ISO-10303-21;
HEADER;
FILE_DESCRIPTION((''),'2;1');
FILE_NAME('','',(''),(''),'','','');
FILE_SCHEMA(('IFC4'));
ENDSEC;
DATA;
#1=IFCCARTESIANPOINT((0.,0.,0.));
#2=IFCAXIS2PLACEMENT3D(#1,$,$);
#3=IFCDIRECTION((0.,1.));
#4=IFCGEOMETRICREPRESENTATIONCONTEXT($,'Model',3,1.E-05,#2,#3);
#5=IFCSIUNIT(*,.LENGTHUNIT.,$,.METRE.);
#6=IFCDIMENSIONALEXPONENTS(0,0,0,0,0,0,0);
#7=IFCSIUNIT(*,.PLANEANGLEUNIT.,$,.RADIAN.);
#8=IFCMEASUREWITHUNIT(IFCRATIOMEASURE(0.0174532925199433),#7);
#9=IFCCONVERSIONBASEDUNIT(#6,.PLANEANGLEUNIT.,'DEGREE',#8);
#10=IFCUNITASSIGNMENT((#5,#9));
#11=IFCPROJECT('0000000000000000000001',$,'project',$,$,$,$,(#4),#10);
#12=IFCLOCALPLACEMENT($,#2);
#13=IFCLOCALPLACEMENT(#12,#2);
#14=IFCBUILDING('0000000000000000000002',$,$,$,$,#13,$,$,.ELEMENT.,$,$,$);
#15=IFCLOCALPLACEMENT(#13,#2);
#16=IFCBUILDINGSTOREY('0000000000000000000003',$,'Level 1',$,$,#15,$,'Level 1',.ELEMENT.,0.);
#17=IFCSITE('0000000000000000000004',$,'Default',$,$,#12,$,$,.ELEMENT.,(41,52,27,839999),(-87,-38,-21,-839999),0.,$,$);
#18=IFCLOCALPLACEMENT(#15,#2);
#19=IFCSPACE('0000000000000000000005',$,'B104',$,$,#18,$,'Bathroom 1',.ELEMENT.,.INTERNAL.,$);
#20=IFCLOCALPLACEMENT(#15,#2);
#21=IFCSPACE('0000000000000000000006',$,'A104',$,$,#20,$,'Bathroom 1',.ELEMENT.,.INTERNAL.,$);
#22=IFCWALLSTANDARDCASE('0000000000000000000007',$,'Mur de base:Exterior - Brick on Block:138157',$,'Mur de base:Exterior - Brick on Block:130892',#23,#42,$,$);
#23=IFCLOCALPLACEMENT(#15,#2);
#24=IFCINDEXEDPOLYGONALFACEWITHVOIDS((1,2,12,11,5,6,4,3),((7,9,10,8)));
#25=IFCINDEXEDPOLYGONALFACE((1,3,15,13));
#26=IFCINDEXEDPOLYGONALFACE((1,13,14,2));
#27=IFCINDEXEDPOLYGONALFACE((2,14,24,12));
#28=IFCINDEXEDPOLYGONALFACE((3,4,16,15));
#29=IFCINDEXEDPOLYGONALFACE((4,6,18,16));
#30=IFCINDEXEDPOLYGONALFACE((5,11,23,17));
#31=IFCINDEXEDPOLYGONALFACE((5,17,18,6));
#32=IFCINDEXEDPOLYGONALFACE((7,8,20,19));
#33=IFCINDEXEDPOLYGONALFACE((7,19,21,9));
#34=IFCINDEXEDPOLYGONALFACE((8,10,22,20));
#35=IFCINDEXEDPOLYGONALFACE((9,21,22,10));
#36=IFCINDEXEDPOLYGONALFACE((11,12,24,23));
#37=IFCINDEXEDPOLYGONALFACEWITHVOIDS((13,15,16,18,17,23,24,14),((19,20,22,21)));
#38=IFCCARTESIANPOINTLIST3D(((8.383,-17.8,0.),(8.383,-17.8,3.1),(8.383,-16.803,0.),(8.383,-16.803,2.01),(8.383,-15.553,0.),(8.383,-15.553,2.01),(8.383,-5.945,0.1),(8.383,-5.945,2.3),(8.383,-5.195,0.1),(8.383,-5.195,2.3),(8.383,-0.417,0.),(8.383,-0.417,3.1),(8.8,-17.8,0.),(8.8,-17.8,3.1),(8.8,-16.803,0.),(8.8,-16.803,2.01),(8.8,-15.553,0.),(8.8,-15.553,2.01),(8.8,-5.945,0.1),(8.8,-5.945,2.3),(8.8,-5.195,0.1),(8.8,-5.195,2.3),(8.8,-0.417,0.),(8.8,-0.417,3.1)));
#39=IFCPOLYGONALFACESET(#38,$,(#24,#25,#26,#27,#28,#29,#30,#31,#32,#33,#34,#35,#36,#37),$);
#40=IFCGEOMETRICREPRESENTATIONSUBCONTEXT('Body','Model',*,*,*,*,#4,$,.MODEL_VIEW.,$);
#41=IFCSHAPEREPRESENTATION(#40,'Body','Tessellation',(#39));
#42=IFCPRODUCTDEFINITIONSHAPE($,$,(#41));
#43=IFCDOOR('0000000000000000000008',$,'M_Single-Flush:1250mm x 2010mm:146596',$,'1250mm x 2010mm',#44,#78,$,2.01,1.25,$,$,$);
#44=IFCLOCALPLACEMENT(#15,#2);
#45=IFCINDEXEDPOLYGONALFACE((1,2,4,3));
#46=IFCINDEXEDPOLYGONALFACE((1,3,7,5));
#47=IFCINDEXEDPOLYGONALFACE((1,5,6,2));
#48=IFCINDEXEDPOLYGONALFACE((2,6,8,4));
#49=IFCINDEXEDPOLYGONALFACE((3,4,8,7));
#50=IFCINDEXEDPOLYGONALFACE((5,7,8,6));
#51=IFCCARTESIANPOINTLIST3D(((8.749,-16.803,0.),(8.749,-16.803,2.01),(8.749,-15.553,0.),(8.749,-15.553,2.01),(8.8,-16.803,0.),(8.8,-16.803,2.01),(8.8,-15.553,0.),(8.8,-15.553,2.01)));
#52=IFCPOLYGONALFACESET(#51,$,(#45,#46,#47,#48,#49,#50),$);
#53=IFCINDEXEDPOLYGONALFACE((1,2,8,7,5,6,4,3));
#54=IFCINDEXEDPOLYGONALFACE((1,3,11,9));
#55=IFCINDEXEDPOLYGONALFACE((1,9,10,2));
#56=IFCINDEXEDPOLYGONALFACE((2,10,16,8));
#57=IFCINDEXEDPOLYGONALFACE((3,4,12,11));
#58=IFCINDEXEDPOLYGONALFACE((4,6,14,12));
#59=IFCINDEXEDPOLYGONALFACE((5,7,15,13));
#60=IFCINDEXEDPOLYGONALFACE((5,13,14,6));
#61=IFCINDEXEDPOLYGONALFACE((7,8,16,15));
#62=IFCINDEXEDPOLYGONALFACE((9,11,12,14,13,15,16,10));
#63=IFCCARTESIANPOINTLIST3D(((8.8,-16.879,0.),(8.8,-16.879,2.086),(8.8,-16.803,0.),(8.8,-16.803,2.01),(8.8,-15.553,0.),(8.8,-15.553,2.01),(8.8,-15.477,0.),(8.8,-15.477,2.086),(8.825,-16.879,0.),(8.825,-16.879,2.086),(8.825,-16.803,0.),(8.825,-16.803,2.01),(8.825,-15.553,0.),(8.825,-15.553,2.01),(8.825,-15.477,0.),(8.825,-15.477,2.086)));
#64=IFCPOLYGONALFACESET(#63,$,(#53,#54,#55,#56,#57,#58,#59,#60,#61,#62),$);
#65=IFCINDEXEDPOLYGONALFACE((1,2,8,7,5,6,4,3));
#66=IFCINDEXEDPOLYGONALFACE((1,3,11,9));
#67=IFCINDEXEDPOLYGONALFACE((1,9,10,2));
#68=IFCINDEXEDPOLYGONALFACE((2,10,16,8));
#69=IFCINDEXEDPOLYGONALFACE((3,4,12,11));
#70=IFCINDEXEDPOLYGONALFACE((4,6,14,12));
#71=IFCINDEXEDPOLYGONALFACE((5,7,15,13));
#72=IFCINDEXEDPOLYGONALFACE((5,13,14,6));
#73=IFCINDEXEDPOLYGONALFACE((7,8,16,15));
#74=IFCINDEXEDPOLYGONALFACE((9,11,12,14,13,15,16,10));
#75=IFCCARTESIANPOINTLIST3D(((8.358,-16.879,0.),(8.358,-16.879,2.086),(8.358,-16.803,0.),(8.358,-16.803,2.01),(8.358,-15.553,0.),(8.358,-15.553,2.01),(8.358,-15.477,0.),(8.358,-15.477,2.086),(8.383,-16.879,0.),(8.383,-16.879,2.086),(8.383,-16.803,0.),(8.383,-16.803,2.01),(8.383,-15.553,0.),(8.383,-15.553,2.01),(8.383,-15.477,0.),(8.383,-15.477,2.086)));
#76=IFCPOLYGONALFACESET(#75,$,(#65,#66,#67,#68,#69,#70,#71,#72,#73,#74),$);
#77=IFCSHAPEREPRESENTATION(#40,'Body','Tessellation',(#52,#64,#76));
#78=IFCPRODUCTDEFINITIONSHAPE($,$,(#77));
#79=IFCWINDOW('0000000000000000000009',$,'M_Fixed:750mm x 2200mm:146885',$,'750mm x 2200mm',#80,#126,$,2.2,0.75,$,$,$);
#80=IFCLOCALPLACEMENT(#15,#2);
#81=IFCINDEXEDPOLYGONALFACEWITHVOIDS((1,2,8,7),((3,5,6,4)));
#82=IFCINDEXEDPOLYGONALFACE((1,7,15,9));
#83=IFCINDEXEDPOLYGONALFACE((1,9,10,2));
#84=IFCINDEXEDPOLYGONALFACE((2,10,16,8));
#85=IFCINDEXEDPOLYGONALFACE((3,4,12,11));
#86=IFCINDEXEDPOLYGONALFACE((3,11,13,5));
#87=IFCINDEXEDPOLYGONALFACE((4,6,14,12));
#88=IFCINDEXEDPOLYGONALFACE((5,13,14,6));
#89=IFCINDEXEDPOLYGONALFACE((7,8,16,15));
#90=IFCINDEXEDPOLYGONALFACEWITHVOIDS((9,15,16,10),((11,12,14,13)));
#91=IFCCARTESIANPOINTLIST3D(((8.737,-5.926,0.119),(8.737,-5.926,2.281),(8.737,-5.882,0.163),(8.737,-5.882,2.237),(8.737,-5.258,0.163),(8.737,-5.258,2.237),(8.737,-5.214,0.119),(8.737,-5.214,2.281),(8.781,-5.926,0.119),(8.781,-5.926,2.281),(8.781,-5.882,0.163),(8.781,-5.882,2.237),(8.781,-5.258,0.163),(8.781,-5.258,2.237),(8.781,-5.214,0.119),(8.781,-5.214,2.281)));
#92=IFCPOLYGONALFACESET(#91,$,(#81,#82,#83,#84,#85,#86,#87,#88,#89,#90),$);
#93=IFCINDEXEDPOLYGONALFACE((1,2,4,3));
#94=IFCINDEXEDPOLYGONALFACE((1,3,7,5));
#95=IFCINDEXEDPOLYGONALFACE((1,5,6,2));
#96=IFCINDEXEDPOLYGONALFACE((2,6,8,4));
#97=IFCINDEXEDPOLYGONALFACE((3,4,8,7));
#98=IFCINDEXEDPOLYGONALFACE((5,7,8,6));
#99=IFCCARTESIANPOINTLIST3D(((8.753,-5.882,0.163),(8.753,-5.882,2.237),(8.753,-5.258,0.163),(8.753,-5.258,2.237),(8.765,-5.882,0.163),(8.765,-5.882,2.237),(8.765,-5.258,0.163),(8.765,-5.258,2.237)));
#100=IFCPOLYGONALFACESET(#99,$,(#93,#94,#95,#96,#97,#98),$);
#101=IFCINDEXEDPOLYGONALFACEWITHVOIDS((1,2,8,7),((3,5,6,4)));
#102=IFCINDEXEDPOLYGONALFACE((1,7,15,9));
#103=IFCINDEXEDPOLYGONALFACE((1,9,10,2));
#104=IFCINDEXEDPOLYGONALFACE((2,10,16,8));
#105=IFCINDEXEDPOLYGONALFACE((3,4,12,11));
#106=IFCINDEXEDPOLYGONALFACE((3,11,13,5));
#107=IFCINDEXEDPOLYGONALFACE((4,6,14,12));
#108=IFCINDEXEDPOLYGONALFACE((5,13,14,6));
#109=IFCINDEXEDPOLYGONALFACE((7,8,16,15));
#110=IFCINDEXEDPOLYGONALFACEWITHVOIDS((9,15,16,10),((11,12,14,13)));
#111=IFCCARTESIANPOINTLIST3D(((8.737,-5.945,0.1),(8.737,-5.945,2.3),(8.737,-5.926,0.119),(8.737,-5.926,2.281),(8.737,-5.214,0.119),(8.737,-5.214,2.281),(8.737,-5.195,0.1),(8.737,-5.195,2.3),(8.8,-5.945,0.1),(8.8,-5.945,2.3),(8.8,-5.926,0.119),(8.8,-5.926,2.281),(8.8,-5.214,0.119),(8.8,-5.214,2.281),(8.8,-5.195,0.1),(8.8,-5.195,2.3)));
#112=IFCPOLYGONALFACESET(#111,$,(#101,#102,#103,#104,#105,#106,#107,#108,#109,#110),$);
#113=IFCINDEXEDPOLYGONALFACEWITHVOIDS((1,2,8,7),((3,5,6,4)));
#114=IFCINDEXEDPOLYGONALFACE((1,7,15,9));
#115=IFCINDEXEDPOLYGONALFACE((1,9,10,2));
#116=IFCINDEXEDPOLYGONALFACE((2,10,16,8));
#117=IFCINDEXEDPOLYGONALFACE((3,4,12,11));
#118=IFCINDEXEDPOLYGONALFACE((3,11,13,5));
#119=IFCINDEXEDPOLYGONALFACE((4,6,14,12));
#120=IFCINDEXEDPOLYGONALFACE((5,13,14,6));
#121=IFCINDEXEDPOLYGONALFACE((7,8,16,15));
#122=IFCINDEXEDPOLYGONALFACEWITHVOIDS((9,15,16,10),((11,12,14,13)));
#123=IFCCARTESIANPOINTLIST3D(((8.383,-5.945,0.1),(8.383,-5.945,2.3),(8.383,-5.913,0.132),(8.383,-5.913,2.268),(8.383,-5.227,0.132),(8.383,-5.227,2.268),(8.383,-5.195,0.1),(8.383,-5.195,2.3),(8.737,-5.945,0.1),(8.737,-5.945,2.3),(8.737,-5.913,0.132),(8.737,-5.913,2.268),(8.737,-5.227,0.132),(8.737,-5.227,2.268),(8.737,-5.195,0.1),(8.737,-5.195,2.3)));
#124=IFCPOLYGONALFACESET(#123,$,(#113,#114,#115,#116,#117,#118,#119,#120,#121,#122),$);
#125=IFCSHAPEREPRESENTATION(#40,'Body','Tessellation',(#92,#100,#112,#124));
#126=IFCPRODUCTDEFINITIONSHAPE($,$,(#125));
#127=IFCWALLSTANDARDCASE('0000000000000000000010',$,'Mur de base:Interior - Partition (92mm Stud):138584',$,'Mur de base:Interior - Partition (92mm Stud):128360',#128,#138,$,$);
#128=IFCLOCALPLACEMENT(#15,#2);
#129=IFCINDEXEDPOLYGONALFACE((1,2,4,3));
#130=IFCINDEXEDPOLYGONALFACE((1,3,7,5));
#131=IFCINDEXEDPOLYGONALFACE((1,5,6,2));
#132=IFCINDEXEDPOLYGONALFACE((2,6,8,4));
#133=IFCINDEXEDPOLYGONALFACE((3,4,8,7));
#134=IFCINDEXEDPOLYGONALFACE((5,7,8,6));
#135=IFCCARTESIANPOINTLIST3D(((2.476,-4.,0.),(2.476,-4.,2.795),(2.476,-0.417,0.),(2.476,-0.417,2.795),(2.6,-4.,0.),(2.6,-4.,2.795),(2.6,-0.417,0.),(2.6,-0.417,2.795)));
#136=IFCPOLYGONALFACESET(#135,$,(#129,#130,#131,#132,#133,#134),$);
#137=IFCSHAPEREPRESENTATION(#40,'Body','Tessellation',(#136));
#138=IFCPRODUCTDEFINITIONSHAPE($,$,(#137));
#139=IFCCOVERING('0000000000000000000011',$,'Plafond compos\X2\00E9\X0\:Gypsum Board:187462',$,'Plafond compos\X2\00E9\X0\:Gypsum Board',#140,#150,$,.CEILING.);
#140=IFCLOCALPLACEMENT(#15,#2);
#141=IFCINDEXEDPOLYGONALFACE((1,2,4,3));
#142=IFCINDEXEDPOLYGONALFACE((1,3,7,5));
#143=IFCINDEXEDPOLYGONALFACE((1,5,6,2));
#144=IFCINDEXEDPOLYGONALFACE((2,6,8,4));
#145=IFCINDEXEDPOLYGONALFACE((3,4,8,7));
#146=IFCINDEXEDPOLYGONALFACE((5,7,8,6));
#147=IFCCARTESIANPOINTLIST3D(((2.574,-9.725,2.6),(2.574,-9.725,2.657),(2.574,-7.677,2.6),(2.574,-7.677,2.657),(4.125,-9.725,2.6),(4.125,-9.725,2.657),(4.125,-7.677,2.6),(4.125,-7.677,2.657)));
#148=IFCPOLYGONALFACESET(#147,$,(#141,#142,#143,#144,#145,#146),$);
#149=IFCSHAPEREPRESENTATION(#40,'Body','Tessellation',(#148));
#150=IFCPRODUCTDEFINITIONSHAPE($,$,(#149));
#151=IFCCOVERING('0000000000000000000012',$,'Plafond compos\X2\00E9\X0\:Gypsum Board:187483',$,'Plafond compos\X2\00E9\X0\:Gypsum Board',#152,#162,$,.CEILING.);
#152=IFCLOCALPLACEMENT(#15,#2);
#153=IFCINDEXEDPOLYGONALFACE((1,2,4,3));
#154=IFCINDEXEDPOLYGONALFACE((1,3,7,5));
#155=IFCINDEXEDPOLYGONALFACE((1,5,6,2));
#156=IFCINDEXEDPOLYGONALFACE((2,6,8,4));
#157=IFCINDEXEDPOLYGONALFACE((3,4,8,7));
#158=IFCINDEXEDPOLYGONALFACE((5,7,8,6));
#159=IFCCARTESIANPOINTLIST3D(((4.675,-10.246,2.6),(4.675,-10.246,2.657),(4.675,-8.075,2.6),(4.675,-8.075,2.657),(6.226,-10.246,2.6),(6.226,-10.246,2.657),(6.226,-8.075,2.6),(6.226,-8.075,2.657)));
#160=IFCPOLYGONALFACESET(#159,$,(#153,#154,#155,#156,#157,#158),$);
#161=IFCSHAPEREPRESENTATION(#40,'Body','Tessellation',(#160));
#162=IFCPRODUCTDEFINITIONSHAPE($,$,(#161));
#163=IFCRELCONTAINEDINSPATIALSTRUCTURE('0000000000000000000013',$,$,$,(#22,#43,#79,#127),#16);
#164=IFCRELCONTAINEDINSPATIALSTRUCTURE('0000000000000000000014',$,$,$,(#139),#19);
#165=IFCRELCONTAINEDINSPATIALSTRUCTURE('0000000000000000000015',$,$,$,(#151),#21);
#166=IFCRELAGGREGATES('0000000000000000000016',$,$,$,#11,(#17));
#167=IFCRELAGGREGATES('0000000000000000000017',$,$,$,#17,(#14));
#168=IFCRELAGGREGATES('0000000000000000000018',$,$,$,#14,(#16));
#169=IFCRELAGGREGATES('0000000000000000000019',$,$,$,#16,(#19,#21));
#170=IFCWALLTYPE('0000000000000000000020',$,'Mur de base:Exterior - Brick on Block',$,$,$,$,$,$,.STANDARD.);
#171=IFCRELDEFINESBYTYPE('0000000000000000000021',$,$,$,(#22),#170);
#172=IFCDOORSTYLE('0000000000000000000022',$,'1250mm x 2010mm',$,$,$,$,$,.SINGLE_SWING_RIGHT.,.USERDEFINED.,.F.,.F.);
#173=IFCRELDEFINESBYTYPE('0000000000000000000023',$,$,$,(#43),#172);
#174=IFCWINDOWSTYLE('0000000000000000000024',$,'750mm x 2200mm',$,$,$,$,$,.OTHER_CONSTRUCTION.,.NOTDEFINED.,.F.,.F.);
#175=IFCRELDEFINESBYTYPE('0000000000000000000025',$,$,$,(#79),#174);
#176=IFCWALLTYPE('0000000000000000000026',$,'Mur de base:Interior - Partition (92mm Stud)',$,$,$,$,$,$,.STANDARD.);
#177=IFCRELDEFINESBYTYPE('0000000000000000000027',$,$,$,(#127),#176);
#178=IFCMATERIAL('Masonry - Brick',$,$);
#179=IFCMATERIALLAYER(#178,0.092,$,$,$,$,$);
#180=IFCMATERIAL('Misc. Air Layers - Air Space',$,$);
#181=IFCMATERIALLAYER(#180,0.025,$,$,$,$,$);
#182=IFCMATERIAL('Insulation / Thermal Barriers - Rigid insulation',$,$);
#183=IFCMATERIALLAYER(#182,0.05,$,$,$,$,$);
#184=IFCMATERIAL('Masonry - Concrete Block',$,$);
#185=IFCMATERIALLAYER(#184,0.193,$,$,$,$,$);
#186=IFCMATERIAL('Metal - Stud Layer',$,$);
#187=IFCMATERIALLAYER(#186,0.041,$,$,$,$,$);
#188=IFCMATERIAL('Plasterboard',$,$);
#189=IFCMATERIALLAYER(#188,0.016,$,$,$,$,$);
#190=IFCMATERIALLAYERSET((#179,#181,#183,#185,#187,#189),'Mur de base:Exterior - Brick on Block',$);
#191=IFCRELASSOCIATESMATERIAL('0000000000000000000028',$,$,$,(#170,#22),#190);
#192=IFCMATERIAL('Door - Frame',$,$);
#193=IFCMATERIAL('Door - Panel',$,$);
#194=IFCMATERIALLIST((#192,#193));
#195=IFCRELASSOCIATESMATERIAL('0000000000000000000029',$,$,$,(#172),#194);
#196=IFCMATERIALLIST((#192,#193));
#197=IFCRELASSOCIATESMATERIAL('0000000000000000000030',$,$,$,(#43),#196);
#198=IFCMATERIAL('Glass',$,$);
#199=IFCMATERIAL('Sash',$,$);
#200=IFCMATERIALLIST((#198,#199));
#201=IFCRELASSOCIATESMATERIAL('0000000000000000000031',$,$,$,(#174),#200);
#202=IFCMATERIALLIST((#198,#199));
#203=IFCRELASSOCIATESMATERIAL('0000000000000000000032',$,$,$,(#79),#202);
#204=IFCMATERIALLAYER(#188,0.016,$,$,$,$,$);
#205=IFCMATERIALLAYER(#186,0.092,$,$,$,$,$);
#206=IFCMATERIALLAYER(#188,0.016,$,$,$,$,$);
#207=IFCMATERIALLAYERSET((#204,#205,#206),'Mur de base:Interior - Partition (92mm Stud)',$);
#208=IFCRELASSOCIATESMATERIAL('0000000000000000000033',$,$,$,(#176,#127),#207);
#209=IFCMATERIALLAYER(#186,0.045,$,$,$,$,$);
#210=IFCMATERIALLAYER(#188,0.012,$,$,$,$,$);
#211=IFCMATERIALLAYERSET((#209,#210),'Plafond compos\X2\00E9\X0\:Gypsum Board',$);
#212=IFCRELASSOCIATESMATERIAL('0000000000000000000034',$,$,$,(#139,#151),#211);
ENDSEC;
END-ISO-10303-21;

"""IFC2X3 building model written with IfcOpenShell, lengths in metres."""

from ifc_helpers import new_model, entity, si_unit, converted_unit, direction, frame, frame_2d, origin, origin_2d_with_axis, place, context, subcontext, project, spatial, polyline, rectangle, outline, extrude, source, transform, mapped, material, material_list, layer, layer_set, layer_usage, type_object, type_shapes, element, fill, save


model = new_model("IFC2X3")

# Units and contexts
model_context = context("Model", 3, precision=1e-05, world=origin(), true_north=direction((0.0, 1.0)))
body_context = subcontext(model_context, "Body", "Model", "MODEL_VIEW")
ifc_project = project(units=[si_unit("LENGTHUNIT", "METRE"), converted_unit("PLANEANGLEUNIT", "DEGREE", entity("IfcRatioMeasure", 0.0174532925199433), si_unit("PLANEANGLEUNIT", "RADIAN"), dimensions=[0, 0, 0, 0, 0, 0, 0])], contexts=[model_context])

# Site, building, storey
site_placement = place(None, origin())
site = spatial("IfcSite", under=ifc_project, at=site_placement, Name="Default", CompositionType="ELEMENT", RefLatitude=(41, 52, 27, 839999), RefLongitude=(-87, -38, -21, -839999), RefElevation=0.0)
building_placement = place(site_placement, origin())
building = spatial("IfcBuilding", under=site, at=building_placement, CompositionType="ELEMENT")
storey_placement = place(building_placement, origin())
storey = spatial("IfcBuildingStorey", under=building, at=storey_placement, Name="Level 1", LongName="Level 1", CompositionType="ELEMENT", Elevation=0.0)

# Shared definitions
ifc_material_1 = material(Name="Masonry - Brick")
ifc_layer_1 = layer(ifc_material_1, 0.092)
ifc_material_2 = material(Name="Misc. Air Layers - Air Space")
ifc_layer_2 = layer(ifc_material_2, 0.025)
ifc_material_3 = material(Name="Insulation / Thermal Barriers - Rigid insulation")
ifc_layer_3 = layer(ifc_material_3, 0.05)
ifc_material_4 = material(Name="Masonry - Concrete Block")
ifc_layer_4 = layer(ifc_material_4, 0.193)
ifc_material_5 = material(Name="Metal - Stud Layer")
ifc_layer_5 = layer(ifc_material_5, 0.041)
ifc_material_6 = material(Name="Plasterboard")
ifc_layer_6 = layer(ifc_material_6, 0.016)
ifc_layer_set_1 = layer_set([ifc_layer_1, ifc_layer_2, ifc_layer_3, ifc_layer_4, ifc_layer_5, ifc_layer_6], Name="Mur de base:Exterior - Brick on Block")
wall_type_1 = type_object("IfcWallType", Name="Mur de base:Exterior - Brick on Block", PredefinedType="STANDARD", material=ifc_layer_set_1)
ifc_material_7 = material(Name="Glass")
ifc_material_8 = material(Name="Sash")
ifc_material_9 = material(Name="Door - Frame")
ifc_material_10 = material(Name="Door - Panel")

# Wall, openings, door, window
ifc_layer_usage_1 = layer_usage(ifc_layer_set_1, "AXIS2", "NEGATIVE", 0.2085)
wall_1_placement = place(storey_placement, frame((8.5915, -0.417, 0.0), z_axis=(0.0, 0.0, 1.0), x_axis=(0.0, -1.0, 0.0)))
wall_1 = element("IfcWallStandardCase", 1, at=wall_1_placement, inside=storey, type_object=wall_type_1, material=ifc_layer_usage_1, Name="Mur de base:Exterior - Brick on Block:138157", ObjectType="Mur de base:Exterior - Brick on Block:130892", context=body_context, shape_type="SweptSolid", body=[
    extrude(rectangle(XDim=17.383, YDim=0.417, at=frame_2d((8.6915, 0.0), x_axis=(-1.0, 0.0))), origin(), (0.0, 0.0, 1.0), 3.1),
])
opening_1_placement = place(wall_1_placement, frame((15.136, -0.2085, 0.0)))
opening_1 = element("IfcOpeningElement", 2, at=opening_1_placement, cuts=wall_1, ObjectType="Opening", context=body_context, shape_type="SweptSolid", body=[
    extrude(rectangle(XDim=1.25, YDim=2.01, at=frame_2d((1.005, 0.625), x_axis=(0.0, 1.0))), frame((0.0, 0.0, 0.0), z_axis=(0.0, 1.0, 0.0), x_axis=(0.0, 0.0, 1.0)), (0.0, 0.0, 1.0), 0.417),
])
opening_2_placement = place(wall_1_placement, frame((4.778, -0.2085, 0.1)))
opening_2 = element("IfcOpeningElement", 3, at=opening_2_placement, cuts=wall_1, ObjectType="Opening", context=body_context, shape_type="SweptSolid", body=[
    extrude(rectangle(XDim=2.2, YDim=0.75, at=frame_2d((1.1, 0.375), x_axis=(1.0, 0.0))), frame((0.0, 0.0, 0.0), z_axis=(0.0, 1.0, 0.0), x_axis=(0.0, 0.0, 1.0)), (0.0, 0.0, 1.0), 0.417),
])
ifc_material_list_1 = material_list([ifc_material_9, ifc_material_10])
ifc_material_list_2 = material_list([ifc_material_9, ifc_material_10])
door_style_1 = type_object("IfcDoorStyle", Name="1250mm x 2010mm", ConstructionType="USERDEFINED", OperationType="SINGLE_SWING_RIGHT", ParameterTakesPrecedence=False, Sizeable=False, material=ifc_material_list_2)
shared_shape_1 = source(origin(), body_context, "Body", "SweptSolid", [
    extrude(rectangle(XDim=0.051, YDim=1.25, at=frame_2d((0.0, 0.0), x_axis=(1.0, 0.0))), frame((0.625, 0.3915, 0.0), z_axis=(0.0, 0.0, 1.0), x_axis=(0.0, 1.0, 0.0)), (0.0, 0.0, 1.0), 2.01),
    extrude(outline(polyline([(-0.701, -1.062), (0.701, -1.062), (0.701, 1.024), (0.625, 1.024), (0.625, -0.986), (-0.625, -0.986), (-0.625, 1.024), (-0.701, 1.024), (-0.701, -1.062)])), frame((0.625, 0.417, 1.024), z_axis=(0.0, 1.0, 0.0), x_axis=(1.0, 0.0, 0.0)), (0.0, 0.0, 1.0), 0.025),
    extrude(outline(polyline([(-1.062, -0.701), (1.024, -0.701), (1.024, -0.625), (-0.986, -0.625), (-0.986, 0.625), (1.024, 0.625), (1.024, 0.701), (-1.062, 0.701), (-1.062, -0.701)])), frame((0.625, -0.025, 1.024), z_axis=(0.0, 1.0, 0.0), x_axis=(0.0, 0.0, -1.0)), (0.0, 0.0, 1.0), 0.025),
])
type_shapes(door_style_1, [shared_shape_1])
door_1_placement = place(opening_1_placement, origin())
door_1 = element("IfcDoor", 4, at=door_1_placement, inside=storey, type_object=door_style_1, material=ifc_material_list_1, Name="M_Single-Flush:1250mm x 2010mm:146596", ObjectType="1250mm x 2010mm", OverallHeight=2.01, OverallWidth=1.25, context=body_context, shape_type="MappedRepresentation", body=[
    mapped(shared_shape_1, transform((0.0, 0.0, 0.0), scale=1.0)),
])
fill(opening_1, door_1)
ifc_material_list_3 = material_list([ifc_material_7, ifc_material_8])
ifc_material_list_4 = material_list([ifc_material_7, ifc_material_8])
window_style_1 = type_object("IfcWindowStyle", Name="750mm x 2200mm", ConstructionType="OTHER_CONSTRUCTION", OperationType="NOTDEFINED", ParameterTakesPrecedence=False, Sizeable=False, material=ifc_material_list_4)
shared_shape_2 = source(origin(), body_context, "Body", "SweptSolid", [
    extrude(outline(polyline([(-0.356, -1.081), (0.356, -1.081), (0.356, 1.081), (-0.356, 1.081), (-0.356, -1.081)]), holes=[polyline([(-0.312, -1.037), (-0.312, 1.037), (0.312, 1.037), (0.312, -1.037), (-0.312, -1.037)])]), frame((0.375, 0.354, 1.1), z_axis=(0.0, 1.0, 0.0), x_axis=(1.0, 0.0, 0.0)), (0.0, 0.0, 1.0), 0.044),
    extrude(rectangle(XDim=0.012, YDim=0.624, at=origin_2d_with_axis()), frame((0.375, 0.376, 0.063), z_axis=(0.0, 0.0, 1.0), x_axis=(0.0, -1.0, 0.0)), (0.0, 0.0, 1.0), 2.074),
    extrude(outline(polyline([(-0.375, -1.1), (0.375, -1.1), (0.375, 1.1), (-0.375, 1.1), (-0.375, -1.1)]), holes=[polyline([(-0.356, -1.081), (-0.356, 1.081), (0.356, 1.081), (0.356, -1.081), (-0.356, -1.081)])]), frame((0.375, 0.354, 1.1), z_axis=(0.0, 1.0, 0.0), x_axis=(1.0, 0.0, 0.0)), (0.0, 0.0, 1.0), 0.063),
    extrude(outline(polyline([(-0.375, -1.1), (0.375, -1.1), (0.375, 1.1), (-0.375, 1.1), (-0.375, -1.1)]), holes=[polyline([(-0.343, -1.068), (-0.343, 1.068), (0.343, 1.068), (0.343, -1.068), (-0.343, -1.068)])]), frame((0.375, 0.0, 1.1), z_axis=(0.0, 1.0, 0.0), x_axis=(1.0, 0.0, 0.0)), (0.0, 0.0, 1.0), 0.354),
])
type_shapes(window_style_1, [shared_shape_2])
window_1_placement = place(opening_2_placement, origin())
window_1 = element("IfcWindow", 5, at=window_1_placement, inside=storey, type_object=window_style_1, material=ifc_material_list_3, Name="M_Fixed:750mm x 2200mm:146885", ObjectType="750mm x 2200mm", OverallHeight=2.2, OverallWidth=0.75, context=body_context, shape_type="MappedRepresentation", body=[
    mapped(shared_shape_2, transform((0.0, 0.0, 0.0), scale=1.0)),
])
fill(opening_2, window_1)

# Wall
ifc_layer_7 = layer(ifc_material_6, 0.016)
ifc_layer_8 = layer(ifc_material_5, 0.092)
ifc_layer_9 = layer(ifc_material_6, 0.016)
ifc_layer_set_2 = layer_set([ifc_layer_7, ifc_layer_8, ifc_layer_9], Name="Mur de base:Interior - Partition (92mm Stud)")
ifc_layer_usage_2 = layer_usage(ifc_layer_set_2, "AXIS2", "NEGATIVE", 0.062)
wall_type_2 = type_object("IfcWallType", Name="Mur de base:Interior - Partition (92mm Stud)", PredefinedType="STANDARD", material=ifc_layer_set_2)
wall_2_placement = place(storey_placement, frame((2.538, -0.417, 0.0), z_axis=(0.0, 0.0, 1.0), x_axis=(0.0, -1.0, 0.0)))
element("IfcWallStandardCase", 6, at=wall_2_placement, inside=storey, type_object=wall_type_2, material=ifc_layer_usage_2, Name="Mur de base:Interior - Partition (92mm Stud):138584", ObjectType="Mur de base:Interior - Partition (92mm Stud):128360", context=body_context, shape_type="SweptSolid", body=[
    extrude(rectangle(XDim=3.583, YDim=0.124, at=frame_2d((1.7915, 0.0), x_axis=(-1.0, 0.0))), origin(), (0.0, 0.0, 1.0), 2.795),
])

# Shared definitions
ifc_layer_10 = layer(ifc_material_5, 0.045)
ifc_layer_11 = layer(ifc_material_6, 0.012)
ifc_layer_set_3 = layer_set([ifc_layer_10, ifc_layer_11], Name="Plafond composé:Gypsum Board")

# Shared definitions
space_1_placement = place(storey_placement, origin())
space_1 = spatial("IfcSpace", under=storey, at=space_1_placement, Name="B104", LongName="Bathroom 1", CompositionType="ELEMENT", InteriorOrExteriorSpace="INTERNAL")

# Covering
ifc_layer_usage_3 = layer_usage(ifc_layer_set_3, "AXIS3", "NEGATIVE", 0.0)
covering_1_placement = place(space_1_placement, origin())
element("IfcCovering", 7, at=covering_1_placement, inside=space_1, material=ifc_layer_usage_3, Name="Plafond composé:Gypsum Board:187462", ObjectType="Plafond composé:Gypsum Board", PredefinedType="CEILING", context=body_context, shape_type="SweptSolid", body=[
    extrude(rectangle(XDim=1.551, YDim=2.048, at=frame_2d((0.0, 0.0), x_axis=(1.0, 0.0))), frame((3.3495, -8.701, 2.6)), (0.0, 0.0, 1.0), 0.057),
])

# Shared definitions
space_2_placement = place(storey_placement, origin())
space_2 = spatial("IfcSpace", under=storey, at=space_2_placement, Name="A104", LongName="Bathroom 1", CompositionType="ELEMENT", InteriorOrExteriorSpace="INTERNAL")

# Covering
ifc_layer_usage_4 = layer_usage(ifc_layer_set_3, "AXIS3", "NEGATIVE", 0.0)
covering_2_placement = place(space_2_placement, origin())
element("IfcCovering", 8, at=covering_2_placement, inside=space_2, material=ifc_layer_usage_4, Name="Plafond composé:Gypsum Board:187483", ObjectType="Plafond composé:Gypsum Board", PredefinedType="CEILING", context=body_context, shape_type="SweptSolid", body=[
    extrude(rectangle(XDim=2.171, YDim=1.551, at=frame_2d((0.0, 0.0), x_axis=(1.0, 0.0))), frame((5.4505, -9.1605, 2.6), z_axis=(0.0, 0.0, 1.0), x_axis=(0.0, -1.0, 0.0)), (0.0, 0.0, 1.0), 0.057),
])

save(model, "model.ifc")
